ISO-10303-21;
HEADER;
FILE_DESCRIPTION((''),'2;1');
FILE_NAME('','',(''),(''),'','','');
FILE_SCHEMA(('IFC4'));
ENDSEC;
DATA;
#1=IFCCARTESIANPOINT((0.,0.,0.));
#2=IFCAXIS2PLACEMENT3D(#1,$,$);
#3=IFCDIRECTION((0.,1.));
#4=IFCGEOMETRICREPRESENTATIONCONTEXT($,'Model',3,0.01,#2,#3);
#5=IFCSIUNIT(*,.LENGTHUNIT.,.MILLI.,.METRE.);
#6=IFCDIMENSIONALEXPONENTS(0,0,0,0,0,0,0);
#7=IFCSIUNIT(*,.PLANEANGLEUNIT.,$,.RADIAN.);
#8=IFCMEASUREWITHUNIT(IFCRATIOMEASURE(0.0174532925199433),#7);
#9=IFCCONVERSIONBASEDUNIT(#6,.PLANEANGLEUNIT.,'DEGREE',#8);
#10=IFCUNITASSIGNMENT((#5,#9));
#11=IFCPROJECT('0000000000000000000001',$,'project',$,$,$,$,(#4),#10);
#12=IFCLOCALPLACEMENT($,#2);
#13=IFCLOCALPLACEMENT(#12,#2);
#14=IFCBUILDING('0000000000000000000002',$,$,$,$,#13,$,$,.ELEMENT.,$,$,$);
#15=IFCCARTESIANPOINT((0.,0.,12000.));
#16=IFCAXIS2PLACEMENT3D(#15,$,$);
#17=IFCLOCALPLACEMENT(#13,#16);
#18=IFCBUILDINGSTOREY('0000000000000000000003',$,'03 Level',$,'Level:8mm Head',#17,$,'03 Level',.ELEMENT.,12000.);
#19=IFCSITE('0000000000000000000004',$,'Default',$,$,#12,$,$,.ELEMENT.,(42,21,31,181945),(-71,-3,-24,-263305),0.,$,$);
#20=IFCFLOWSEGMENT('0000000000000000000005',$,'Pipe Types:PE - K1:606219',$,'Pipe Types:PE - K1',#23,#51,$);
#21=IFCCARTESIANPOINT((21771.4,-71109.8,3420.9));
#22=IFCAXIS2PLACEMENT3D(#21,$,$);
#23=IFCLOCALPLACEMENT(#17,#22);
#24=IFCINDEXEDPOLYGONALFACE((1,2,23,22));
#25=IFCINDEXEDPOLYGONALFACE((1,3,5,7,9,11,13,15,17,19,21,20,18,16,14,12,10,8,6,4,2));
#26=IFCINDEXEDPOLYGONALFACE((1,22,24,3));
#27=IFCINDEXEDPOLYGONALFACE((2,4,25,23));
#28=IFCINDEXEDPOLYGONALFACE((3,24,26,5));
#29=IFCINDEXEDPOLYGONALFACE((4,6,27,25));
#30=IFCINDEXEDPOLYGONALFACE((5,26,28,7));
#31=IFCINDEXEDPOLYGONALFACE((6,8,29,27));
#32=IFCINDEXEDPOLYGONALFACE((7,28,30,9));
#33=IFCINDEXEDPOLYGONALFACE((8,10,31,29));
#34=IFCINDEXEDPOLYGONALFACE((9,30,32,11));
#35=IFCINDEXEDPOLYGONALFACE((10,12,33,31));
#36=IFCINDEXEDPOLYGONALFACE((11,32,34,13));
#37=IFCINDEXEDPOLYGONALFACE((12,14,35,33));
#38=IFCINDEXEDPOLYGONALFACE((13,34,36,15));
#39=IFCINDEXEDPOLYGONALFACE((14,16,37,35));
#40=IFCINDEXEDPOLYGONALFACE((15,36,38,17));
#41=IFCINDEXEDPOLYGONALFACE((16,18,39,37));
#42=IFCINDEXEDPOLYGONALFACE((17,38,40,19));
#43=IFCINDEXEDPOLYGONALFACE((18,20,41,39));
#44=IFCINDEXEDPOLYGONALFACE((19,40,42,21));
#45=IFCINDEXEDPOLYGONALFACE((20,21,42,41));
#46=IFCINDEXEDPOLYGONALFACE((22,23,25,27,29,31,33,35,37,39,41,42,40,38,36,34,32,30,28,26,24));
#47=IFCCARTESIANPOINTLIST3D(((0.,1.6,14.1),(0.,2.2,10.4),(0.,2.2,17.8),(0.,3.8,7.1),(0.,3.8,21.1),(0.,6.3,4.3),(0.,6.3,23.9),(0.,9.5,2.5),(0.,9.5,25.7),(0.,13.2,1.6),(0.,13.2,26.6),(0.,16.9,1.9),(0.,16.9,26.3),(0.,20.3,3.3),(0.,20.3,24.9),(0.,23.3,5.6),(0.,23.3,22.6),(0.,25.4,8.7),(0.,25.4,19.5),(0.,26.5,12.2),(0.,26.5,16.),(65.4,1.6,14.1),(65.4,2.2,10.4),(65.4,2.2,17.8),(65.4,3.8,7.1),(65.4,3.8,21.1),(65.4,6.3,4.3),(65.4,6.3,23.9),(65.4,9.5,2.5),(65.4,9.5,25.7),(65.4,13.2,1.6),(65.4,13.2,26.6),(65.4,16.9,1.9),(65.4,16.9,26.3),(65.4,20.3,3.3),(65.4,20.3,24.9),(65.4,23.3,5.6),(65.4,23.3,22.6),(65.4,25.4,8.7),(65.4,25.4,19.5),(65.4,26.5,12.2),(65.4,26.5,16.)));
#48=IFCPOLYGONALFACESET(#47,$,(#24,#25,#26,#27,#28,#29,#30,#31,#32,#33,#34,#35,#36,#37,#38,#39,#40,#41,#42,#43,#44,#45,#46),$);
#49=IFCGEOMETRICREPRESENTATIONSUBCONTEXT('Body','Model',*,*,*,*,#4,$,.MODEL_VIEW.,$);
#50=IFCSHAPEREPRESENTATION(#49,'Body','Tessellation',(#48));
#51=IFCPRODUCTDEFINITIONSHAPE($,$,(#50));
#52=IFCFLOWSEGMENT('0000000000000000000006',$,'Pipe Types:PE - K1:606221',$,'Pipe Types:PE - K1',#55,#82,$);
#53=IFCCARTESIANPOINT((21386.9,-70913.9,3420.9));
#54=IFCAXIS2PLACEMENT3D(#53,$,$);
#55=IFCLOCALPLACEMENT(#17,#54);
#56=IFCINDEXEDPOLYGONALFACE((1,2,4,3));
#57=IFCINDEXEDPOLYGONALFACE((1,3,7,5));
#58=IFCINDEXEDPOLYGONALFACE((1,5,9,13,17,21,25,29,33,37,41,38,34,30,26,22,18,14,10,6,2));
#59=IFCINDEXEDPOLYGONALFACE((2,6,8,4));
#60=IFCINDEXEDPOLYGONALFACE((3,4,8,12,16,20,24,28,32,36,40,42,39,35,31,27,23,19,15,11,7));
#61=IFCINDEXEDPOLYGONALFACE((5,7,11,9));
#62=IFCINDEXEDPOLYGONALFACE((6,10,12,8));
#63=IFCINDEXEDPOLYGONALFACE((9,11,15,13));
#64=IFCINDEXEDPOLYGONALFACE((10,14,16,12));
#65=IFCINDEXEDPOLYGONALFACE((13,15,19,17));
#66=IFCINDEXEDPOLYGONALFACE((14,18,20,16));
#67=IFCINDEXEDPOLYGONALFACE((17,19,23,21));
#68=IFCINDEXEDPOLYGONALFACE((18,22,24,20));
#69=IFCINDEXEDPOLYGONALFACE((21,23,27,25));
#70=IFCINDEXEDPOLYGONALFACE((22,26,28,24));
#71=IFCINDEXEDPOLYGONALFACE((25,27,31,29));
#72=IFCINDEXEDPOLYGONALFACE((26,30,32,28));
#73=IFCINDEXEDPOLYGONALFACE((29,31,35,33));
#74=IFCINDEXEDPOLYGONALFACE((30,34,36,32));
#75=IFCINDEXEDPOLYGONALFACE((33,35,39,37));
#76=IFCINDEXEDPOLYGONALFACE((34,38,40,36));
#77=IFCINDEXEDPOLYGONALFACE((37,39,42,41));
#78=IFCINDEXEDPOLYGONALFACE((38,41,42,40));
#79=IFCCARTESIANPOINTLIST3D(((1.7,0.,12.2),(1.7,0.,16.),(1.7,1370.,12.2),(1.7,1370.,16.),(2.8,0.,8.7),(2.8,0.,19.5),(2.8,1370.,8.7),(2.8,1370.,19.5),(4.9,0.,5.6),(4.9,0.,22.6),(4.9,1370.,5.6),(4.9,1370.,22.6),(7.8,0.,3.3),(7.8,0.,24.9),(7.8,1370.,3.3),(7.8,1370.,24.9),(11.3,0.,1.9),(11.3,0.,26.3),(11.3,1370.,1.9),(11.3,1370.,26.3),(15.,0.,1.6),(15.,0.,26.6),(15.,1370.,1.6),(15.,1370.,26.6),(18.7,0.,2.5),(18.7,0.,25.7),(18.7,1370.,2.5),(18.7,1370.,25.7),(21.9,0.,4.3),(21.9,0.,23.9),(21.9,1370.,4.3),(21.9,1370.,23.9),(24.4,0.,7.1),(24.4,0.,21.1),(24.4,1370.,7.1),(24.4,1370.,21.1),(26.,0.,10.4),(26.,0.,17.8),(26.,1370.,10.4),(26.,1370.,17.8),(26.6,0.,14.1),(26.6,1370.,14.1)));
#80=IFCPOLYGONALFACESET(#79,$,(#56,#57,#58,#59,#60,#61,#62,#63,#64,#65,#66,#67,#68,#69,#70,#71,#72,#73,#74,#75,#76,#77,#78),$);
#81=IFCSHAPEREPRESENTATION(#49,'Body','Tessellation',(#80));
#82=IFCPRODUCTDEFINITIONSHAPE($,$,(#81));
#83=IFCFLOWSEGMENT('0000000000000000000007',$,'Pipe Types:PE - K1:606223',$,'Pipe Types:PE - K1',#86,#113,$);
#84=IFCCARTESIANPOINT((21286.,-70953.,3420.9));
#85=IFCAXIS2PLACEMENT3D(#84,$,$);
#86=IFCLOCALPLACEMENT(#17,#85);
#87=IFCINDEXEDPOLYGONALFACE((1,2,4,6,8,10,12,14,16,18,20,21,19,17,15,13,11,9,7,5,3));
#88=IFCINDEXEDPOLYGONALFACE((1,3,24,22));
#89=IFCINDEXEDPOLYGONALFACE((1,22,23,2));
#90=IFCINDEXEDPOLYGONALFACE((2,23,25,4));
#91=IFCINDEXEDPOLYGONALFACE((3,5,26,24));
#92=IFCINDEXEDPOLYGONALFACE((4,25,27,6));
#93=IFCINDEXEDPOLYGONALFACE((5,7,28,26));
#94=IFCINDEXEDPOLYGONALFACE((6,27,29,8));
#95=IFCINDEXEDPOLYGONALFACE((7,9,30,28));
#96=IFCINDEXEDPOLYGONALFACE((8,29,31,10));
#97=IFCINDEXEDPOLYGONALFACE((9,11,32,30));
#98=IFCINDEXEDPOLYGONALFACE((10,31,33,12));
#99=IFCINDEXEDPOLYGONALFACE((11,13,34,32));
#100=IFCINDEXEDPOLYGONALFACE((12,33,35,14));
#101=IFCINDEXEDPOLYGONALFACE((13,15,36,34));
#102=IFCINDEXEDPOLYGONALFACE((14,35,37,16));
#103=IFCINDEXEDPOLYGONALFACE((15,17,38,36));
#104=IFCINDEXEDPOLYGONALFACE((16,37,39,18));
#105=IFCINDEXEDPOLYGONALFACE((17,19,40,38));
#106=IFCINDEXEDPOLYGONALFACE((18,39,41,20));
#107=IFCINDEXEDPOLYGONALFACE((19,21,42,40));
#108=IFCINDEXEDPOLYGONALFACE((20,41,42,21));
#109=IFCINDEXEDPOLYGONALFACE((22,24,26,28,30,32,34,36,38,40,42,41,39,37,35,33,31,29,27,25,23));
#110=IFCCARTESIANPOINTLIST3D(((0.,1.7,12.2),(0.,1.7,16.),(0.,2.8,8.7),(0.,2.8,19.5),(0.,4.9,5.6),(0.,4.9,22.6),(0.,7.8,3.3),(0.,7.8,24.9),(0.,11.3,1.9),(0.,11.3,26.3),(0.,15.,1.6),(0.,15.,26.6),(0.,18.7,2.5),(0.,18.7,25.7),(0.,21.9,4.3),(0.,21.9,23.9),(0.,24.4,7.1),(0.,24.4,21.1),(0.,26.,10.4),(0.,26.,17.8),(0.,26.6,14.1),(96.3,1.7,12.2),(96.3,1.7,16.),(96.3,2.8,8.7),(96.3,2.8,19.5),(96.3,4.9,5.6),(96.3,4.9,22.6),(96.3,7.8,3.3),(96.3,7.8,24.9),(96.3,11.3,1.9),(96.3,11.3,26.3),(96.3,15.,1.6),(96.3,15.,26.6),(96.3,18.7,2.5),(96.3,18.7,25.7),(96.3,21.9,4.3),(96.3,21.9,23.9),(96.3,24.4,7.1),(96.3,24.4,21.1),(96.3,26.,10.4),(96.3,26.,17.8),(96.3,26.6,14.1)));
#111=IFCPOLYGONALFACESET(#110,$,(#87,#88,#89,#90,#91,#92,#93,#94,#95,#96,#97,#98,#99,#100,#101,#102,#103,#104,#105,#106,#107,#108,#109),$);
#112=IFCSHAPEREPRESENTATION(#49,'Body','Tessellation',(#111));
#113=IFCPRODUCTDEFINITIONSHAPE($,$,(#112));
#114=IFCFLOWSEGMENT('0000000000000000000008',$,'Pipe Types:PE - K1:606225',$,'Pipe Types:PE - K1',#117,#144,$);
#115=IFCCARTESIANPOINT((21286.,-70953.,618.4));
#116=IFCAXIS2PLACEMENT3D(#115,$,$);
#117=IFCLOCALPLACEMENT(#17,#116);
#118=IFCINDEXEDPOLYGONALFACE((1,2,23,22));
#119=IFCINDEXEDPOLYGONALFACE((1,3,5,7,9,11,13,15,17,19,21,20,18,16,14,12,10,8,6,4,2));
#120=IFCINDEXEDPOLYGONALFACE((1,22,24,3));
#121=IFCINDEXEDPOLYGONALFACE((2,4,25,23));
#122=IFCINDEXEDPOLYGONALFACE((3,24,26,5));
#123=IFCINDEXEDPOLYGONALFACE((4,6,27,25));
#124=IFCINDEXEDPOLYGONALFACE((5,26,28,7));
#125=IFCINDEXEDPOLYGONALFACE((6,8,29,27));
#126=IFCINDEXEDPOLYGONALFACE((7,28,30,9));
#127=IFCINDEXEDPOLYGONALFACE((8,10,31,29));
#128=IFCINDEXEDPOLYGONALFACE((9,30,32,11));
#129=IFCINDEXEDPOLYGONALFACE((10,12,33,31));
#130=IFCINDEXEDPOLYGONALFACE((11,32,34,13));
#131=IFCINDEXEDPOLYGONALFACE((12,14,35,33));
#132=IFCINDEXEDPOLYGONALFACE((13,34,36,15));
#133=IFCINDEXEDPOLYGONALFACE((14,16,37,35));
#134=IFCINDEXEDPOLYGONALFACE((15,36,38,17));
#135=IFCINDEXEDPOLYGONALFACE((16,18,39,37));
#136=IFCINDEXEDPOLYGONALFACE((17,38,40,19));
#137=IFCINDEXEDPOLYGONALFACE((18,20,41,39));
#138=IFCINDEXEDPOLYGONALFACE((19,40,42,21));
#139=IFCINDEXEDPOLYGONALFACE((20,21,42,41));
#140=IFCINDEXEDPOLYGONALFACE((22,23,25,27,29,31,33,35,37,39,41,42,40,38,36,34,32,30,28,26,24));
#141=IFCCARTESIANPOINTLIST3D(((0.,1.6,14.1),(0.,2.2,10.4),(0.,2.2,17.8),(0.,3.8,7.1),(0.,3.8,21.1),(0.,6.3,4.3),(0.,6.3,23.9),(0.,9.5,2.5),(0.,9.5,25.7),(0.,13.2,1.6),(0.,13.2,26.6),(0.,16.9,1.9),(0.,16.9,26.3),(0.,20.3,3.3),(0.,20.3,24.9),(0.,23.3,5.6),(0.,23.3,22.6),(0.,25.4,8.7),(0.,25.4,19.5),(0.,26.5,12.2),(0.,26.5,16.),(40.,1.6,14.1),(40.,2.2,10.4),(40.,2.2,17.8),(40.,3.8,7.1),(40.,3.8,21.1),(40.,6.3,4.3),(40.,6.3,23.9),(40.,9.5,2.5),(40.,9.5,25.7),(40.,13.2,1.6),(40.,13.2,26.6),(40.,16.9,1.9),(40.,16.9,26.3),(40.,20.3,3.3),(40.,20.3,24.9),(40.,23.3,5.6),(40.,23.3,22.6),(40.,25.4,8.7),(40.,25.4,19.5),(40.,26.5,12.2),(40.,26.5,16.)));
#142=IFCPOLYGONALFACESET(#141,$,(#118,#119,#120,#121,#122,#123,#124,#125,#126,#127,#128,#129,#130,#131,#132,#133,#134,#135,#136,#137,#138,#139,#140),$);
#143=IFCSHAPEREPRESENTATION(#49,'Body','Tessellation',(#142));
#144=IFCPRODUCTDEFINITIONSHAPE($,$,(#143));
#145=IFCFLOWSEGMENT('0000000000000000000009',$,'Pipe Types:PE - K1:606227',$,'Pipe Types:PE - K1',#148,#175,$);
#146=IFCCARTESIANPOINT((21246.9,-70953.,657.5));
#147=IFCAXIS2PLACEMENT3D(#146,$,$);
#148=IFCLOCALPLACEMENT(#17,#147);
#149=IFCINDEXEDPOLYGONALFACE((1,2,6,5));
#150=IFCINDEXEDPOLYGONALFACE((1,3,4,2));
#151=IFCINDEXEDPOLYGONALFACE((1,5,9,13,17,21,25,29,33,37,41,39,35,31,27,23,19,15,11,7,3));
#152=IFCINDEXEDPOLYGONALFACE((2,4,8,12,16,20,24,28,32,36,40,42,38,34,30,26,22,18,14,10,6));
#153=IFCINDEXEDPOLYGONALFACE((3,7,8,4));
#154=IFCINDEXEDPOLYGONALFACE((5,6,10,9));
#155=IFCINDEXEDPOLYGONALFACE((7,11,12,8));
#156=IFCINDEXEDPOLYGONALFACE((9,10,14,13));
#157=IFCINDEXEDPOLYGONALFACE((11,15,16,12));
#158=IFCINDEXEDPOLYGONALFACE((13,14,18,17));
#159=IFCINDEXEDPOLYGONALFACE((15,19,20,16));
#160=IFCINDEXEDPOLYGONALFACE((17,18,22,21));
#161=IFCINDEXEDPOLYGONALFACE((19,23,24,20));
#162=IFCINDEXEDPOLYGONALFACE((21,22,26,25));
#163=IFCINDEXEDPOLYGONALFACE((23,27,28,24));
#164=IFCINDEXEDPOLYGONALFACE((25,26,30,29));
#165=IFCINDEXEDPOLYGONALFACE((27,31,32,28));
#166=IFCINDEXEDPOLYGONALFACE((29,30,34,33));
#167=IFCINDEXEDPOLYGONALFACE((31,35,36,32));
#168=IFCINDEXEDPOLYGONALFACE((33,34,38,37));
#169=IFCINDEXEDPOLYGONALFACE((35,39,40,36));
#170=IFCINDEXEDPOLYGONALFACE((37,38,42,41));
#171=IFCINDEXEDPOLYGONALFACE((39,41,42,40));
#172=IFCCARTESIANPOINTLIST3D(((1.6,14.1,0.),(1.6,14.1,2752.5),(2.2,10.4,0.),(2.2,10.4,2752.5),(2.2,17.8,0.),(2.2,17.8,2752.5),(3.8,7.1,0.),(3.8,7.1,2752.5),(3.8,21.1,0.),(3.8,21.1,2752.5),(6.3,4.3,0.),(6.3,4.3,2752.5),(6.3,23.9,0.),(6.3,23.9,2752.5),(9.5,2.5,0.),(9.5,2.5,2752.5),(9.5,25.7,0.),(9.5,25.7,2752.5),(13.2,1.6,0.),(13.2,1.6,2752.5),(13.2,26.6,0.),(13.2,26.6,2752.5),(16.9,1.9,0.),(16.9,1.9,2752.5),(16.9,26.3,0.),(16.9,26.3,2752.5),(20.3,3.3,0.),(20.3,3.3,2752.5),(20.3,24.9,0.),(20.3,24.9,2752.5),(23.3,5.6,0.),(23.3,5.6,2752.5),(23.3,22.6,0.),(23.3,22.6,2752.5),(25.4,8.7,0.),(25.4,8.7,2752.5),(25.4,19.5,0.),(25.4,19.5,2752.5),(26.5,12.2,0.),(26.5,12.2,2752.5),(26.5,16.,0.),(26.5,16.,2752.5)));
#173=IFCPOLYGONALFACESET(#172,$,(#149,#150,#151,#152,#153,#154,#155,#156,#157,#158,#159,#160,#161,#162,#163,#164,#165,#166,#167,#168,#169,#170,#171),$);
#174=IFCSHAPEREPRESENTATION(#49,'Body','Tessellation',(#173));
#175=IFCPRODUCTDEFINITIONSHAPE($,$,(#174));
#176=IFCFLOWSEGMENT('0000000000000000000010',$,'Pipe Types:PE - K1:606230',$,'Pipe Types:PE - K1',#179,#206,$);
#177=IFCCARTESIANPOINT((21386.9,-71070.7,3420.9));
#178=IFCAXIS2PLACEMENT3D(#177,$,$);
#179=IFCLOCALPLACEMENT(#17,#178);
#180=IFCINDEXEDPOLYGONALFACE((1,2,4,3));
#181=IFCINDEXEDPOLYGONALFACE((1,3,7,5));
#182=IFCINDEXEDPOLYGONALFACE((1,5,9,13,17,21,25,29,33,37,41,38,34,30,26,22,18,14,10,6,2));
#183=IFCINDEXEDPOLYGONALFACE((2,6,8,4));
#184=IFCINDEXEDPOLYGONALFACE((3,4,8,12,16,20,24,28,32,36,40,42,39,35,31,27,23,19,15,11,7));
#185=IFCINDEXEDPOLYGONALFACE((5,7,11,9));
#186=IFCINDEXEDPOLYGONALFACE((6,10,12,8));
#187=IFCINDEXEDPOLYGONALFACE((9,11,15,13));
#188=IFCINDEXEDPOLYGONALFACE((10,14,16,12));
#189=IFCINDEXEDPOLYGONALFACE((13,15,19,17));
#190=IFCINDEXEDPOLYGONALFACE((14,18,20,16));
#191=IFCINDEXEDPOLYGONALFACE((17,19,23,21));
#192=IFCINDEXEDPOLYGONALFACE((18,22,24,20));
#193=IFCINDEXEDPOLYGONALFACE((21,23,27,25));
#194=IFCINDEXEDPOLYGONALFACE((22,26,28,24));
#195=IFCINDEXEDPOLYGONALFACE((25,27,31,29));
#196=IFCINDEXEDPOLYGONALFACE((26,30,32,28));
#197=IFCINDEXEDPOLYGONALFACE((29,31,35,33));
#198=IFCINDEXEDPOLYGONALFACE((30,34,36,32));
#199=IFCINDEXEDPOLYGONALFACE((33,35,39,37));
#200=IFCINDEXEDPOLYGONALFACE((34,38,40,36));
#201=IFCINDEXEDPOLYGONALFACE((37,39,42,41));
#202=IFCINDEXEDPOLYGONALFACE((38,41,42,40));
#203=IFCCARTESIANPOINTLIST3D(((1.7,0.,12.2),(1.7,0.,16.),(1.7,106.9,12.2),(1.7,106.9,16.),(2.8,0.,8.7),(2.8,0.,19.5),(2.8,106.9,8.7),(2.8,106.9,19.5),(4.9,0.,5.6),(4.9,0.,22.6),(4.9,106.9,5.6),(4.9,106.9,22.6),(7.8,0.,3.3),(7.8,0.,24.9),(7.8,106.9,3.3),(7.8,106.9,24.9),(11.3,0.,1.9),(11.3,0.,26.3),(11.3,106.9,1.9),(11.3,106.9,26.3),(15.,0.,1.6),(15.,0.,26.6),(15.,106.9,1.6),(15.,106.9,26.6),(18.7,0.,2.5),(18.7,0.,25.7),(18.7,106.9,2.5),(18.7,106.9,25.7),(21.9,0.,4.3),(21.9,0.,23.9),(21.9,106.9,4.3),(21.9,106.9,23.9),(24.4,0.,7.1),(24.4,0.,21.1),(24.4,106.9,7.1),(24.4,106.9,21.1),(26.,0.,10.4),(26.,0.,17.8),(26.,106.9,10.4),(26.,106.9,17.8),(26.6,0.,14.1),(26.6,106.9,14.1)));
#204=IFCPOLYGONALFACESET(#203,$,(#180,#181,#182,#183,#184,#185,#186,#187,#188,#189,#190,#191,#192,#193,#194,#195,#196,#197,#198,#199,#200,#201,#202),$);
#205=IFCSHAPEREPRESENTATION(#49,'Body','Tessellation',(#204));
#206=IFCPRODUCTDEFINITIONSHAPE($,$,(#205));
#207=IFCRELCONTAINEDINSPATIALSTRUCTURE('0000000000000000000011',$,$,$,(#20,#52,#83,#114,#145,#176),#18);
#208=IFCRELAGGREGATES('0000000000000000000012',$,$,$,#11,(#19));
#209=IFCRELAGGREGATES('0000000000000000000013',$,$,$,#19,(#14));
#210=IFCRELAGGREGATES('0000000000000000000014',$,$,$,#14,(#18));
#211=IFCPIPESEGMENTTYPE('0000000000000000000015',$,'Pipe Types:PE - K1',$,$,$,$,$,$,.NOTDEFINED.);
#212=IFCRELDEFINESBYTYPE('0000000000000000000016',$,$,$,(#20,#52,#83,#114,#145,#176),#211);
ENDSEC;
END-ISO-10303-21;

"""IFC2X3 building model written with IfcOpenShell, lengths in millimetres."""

from ifc_helpers import new_model, entity, si_unit, converted_unit, direction, frame, frame_2d, origin, origin_2d_with_axis, place, context, subcontext, project, spatial, circle, extrude, type_object, element, save


model = new_model("IFC2X3")

# Units and contexts
model_context = context("Model", 3, precision=0.01, world=origin(), true_north=direction((0.0, 1.0)))
body_context = subcontext(model_context, "Body", "Model", "MODEL_VIEW")
ifc_project = project(units=[si_unit("LENGTHUNIT", "METRE", prefix="MILLI"), converted_unit("PLANEANGLEUNIT", "DEGREE", entity("IfcRatioMeasure", 0.0174532925199433), si_unit("PLANEANGLEUNIT", "RADIAN"), dimensions=[0, 0, 0, 0, 0, 0, 0])], contexts=[model_context])

# Site, building, storey
site_placement = place(None, origin())
site = spatial("IfcSite", under=ifc_project, at=site_placement, Name="Default", CompositionType="ELEMENT", RefLatitude=(42, 21, 31, 181945), RefLongitude=(-71, -3, -24, -263305), RefElevation=0.0)
building_placement = place(site_placement, origin())
building = spatial("IfcBuilding", under=site, at=building_placement, CompositionType="ELEMENT")
storey_placement = place(building_placement, frame((0.0, 0.0, 12000.0)))
storey = spatial("IfcBuildingStorey", under=building, at=storey_placement, Name="03 Level", ObjectType="Level:8mm Head", LongName="03 Level", CompositionType="ELEMENT", Elevation=12000.0)

# Flow segments
pipe_segment_type = type_object("IfcPipeSegmentType", Name="Pipe Types:PE - K1", PredefinedType="NOTDEFINED")
flow_segment_1_placement = place(storey_placement, frame((21771.4, -71109.8, 3420.9)))
element("IfcFlowSegment", 1, at=flow_segment_1_placement, inside=storey, type_object=pipe_segment_type, Name="Pipe Types:PE - K1:606219", ObjectType="Pipe Types:PE - K1", context=body_context, shape_type="SweptSolid", body=[
    extrude(circle(Radius=12.5, at=origin_2d_with_axis()), frame((0.0, 14.1, 14.1), z_axis=(1.0, 0.0, 0.0), x_axis=(0.0, -1.0, 0.0)), (0.0, 0.0, 1.0), 65.4),
])
flow_segment_2_placement = place(storey_placement, frame((21386.9, -70913.9, 3420.9)))
element("IfcFlowSegment", 2, at=flow_segment_2_placement, inside=storey, type_object=pipe_segment_type, Name="Pipe Types:PE - K1:606221", ObjectType="Pipe Types:PE - K1", context=body_context, shape_type="SweptSolid", body=[
    extrude(circle(Radius=12.5, at=origin_2d_with_axis()), frame((14.1, 0.0, 14.1), z_axis=(0.0, 1.0, 0.0), x_axis=(1.0, 0.0, 0.0)), (0.0, 0.0, 1.0), 1370.0),
])
flow_segment_3_placement = place(storey_placement, frame((21286.0, -70953.0, 3420.9)))
element("IfcFlowSegment", 3, at=flow_segment_3_placement, inside=storey, type_object=pipe_segment_type, Name="Pipe Types:PE - K1:606223", ObjectType="Pipe Types:PE - K1", context=body_context, shape_type="SweptSolid", body=[
    extrude(circle(Radius=12.5, at=frame_2d((0.0, 0.0), x_axis=(1.0, 0.0))), frame((0.0, 14.1, 14.1), z_axis=(1.0, 0.0, 0.0), x_axis=(0.0, 1.0, 0.0)), (0.0, 0.0, 1.0), 96.3),
])
flow_segment_4_placement = place(storey_placement, frame((21286.0, -70953.0, 618.4)))
element("IfcFlowSegment", 4, at=flow_segment_4_placement, inside=storey, type_object=pipe_segment_type, Name="Pipe Types:PE - K1:606225", ObjectType="Pipe Types:PE - K1", context=body_context, shape_type="SweptSolid", body=[
    extrude(circle(Radius=12.5, at=origin_2d_with_axis()), frame((0.0, 14.1, 14.1), z_axis=(1.0, 0.0, 0.0), x_axis=(0.0, -1.0, 0.0)), (0.0, 0.0, 1.0), 40.0),
])
flow_segment_5_placement = place(storey_placement, frame((21246.9, -70953.0, 657.5)))
element("IfcFlowSegment", 5, at=flow_segment_5_placement, inside=storey, type_object=pipe_segment_type, Name="Pipe Types:PE - K1:606227", ObjectType="Pipe Types:PE - K1", context=body_context, shape_type="SweptSolid", body=[
    extrude(circle(Radius=12.5, at=origin_2d_with_axis()), frame((14.1, 14.1, 0.0), z_axis=(0.0, 0.0, 1.0), x_axis=(-1.0, 0.0, 0.0)), (0.0, 0.0, 1.0), 2752.5),
])
flow_segment_6_placement = place(storey_placement, frame((21386.9, -71070.7, 3420.9)))
element("IfcFlowSegment", 6, at=flow_segment_6_placement, inside=storey, type_object=pipe_segment_type, Name="Pipe Types:PE - K1:606230", ObjectType="Pipe Types:PE - K1", context=body_context, shape_type="SweptSolid", body=[
    extrude(circle(Radius=12.5, at=frame_2d((0.0, 0.0), x_axis=(1.0, 0.0))), frame((14.1, 0.0, 14.1), z_axis=(0.0, 1.0, 0.0), x_axis=(1.0, 0.0, 0.0)), (0.0, 0.0, 1.0), 106.9),
])

save(model, "model.ifc")
